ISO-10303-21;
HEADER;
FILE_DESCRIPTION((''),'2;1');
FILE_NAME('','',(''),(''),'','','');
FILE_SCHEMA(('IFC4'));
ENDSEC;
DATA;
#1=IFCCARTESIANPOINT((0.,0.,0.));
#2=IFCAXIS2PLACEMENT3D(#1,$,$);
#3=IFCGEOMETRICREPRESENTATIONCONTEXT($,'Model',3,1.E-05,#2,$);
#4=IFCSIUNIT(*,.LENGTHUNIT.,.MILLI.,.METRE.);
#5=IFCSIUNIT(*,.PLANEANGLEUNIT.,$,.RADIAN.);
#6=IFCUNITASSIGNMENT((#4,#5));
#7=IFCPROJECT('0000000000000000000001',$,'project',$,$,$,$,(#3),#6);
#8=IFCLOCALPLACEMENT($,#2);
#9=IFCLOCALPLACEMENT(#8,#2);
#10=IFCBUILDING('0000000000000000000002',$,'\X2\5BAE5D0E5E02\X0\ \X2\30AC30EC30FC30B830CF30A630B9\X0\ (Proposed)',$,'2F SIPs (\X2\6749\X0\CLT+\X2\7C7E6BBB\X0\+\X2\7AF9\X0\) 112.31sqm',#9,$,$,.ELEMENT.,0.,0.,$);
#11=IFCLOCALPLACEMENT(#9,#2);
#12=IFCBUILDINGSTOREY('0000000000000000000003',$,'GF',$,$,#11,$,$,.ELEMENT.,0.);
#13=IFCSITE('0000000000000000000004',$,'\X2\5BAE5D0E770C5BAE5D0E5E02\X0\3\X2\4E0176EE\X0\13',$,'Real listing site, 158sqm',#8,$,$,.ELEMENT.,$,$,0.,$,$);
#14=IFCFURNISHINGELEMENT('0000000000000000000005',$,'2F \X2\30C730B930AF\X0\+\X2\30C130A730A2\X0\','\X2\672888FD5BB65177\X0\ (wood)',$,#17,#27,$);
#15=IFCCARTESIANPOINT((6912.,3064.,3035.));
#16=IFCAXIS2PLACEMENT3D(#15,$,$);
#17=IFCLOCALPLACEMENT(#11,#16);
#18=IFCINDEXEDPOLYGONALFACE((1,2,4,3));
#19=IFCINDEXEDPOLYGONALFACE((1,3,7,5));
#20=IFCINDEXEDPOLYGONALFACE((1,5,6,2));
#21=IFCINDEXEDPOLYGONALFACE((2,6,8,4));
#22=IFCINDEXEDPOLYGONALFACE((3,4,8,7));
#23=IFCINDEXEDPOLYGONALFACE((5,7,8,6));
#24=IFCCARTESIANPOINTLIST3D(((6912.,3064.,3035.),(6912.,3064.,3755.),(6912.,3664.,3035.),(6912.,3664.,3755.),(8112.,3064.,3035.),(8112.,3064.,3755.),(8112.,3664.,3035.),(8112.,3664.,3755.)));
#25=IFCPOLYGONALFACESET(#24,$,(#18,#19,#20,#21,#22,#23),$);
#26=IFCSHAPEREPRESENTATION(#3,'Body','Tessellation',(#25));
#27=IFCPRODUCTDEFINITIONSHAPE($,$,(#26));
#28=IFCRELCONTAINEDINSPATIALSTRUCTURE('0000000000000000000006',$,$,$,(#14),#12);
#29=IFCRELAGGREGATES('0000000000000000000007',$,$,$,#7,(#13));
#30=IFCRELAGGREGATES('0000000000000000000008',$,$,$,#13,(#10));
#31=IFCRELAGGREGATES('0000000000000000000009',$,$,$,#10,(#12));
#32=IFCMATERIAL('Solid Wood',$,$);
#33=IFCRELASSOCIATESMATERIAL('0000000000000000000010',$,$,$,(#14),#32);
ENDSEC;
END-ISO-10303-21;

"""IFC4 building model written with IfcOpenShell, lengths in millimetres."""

from ifc_helpers import new_model, si_unit, frame, frame_2d, origin, place, context, project, spatial, rectangle, extrude, material, element, save


model = new_model("IFC4")

# Units and contexts
model_context = context("Model", 3, precision=1e-05, world=origin())
ifc_project = project(units=[si_unit("LENGTHUNIT", "METRE", prefix="MILLI"), si_unit("PLANEANGLEUNIT", "RADIAN")], contexts=[model_context])

# Site, building, storey
site_placement = place(None, origin())
site = spatial("IfcSite", under=ifc_project, at=site_placement, Name="宮崎県宮崎市3丁目13", ObjectType="Real listing site, 158sqm", CompositionType="ELEMENT", RefElevation=0.0)
building_placement = place(site_placement, origin())
building = spatial("IfcBuilding", under=site, at=building_placement, Name="宮崎市 ガレージハウス (Proposed)", ObjectType="2F SIPs (杉CLT+籾殻+竹) 112.31sqm", CompositionType="ELEMENT", ElevationOfRefHeight=0.0, ElevationOfTerrain=0.0)
storey_placement = place(building_placement, origin())
storey = spatial("IfcBuildingStorey", under=building, at=storey_placement, Name="GF", CompositionType="ELEMENT", Elevation=0.0)

# Shared definitions
ifc_material_1 = material(Name="Solid Wood")

# Furnishing element
furnishing_1_placement = place(storey_placement, frame((6912.0, 3064.0, 3035.0)))
element("IfcFurnishingElement", 1, at=furnishing_1_placement, inside=storey, material=ifc_material_1, Name="2F デスク+チェア", Description="木製家具 (wood)", context=model_context, shape_type="SweptSolid", body=[
    extrude(rectangle(XDim=1200.0, YDim=600.0, at=frame_2d((600.0, 300.0))), frame((6912.0, 3064.0, 3035.0)), (0.0, 0.0, 1.0), 720.0),
])

save(model, "model.ifc")
